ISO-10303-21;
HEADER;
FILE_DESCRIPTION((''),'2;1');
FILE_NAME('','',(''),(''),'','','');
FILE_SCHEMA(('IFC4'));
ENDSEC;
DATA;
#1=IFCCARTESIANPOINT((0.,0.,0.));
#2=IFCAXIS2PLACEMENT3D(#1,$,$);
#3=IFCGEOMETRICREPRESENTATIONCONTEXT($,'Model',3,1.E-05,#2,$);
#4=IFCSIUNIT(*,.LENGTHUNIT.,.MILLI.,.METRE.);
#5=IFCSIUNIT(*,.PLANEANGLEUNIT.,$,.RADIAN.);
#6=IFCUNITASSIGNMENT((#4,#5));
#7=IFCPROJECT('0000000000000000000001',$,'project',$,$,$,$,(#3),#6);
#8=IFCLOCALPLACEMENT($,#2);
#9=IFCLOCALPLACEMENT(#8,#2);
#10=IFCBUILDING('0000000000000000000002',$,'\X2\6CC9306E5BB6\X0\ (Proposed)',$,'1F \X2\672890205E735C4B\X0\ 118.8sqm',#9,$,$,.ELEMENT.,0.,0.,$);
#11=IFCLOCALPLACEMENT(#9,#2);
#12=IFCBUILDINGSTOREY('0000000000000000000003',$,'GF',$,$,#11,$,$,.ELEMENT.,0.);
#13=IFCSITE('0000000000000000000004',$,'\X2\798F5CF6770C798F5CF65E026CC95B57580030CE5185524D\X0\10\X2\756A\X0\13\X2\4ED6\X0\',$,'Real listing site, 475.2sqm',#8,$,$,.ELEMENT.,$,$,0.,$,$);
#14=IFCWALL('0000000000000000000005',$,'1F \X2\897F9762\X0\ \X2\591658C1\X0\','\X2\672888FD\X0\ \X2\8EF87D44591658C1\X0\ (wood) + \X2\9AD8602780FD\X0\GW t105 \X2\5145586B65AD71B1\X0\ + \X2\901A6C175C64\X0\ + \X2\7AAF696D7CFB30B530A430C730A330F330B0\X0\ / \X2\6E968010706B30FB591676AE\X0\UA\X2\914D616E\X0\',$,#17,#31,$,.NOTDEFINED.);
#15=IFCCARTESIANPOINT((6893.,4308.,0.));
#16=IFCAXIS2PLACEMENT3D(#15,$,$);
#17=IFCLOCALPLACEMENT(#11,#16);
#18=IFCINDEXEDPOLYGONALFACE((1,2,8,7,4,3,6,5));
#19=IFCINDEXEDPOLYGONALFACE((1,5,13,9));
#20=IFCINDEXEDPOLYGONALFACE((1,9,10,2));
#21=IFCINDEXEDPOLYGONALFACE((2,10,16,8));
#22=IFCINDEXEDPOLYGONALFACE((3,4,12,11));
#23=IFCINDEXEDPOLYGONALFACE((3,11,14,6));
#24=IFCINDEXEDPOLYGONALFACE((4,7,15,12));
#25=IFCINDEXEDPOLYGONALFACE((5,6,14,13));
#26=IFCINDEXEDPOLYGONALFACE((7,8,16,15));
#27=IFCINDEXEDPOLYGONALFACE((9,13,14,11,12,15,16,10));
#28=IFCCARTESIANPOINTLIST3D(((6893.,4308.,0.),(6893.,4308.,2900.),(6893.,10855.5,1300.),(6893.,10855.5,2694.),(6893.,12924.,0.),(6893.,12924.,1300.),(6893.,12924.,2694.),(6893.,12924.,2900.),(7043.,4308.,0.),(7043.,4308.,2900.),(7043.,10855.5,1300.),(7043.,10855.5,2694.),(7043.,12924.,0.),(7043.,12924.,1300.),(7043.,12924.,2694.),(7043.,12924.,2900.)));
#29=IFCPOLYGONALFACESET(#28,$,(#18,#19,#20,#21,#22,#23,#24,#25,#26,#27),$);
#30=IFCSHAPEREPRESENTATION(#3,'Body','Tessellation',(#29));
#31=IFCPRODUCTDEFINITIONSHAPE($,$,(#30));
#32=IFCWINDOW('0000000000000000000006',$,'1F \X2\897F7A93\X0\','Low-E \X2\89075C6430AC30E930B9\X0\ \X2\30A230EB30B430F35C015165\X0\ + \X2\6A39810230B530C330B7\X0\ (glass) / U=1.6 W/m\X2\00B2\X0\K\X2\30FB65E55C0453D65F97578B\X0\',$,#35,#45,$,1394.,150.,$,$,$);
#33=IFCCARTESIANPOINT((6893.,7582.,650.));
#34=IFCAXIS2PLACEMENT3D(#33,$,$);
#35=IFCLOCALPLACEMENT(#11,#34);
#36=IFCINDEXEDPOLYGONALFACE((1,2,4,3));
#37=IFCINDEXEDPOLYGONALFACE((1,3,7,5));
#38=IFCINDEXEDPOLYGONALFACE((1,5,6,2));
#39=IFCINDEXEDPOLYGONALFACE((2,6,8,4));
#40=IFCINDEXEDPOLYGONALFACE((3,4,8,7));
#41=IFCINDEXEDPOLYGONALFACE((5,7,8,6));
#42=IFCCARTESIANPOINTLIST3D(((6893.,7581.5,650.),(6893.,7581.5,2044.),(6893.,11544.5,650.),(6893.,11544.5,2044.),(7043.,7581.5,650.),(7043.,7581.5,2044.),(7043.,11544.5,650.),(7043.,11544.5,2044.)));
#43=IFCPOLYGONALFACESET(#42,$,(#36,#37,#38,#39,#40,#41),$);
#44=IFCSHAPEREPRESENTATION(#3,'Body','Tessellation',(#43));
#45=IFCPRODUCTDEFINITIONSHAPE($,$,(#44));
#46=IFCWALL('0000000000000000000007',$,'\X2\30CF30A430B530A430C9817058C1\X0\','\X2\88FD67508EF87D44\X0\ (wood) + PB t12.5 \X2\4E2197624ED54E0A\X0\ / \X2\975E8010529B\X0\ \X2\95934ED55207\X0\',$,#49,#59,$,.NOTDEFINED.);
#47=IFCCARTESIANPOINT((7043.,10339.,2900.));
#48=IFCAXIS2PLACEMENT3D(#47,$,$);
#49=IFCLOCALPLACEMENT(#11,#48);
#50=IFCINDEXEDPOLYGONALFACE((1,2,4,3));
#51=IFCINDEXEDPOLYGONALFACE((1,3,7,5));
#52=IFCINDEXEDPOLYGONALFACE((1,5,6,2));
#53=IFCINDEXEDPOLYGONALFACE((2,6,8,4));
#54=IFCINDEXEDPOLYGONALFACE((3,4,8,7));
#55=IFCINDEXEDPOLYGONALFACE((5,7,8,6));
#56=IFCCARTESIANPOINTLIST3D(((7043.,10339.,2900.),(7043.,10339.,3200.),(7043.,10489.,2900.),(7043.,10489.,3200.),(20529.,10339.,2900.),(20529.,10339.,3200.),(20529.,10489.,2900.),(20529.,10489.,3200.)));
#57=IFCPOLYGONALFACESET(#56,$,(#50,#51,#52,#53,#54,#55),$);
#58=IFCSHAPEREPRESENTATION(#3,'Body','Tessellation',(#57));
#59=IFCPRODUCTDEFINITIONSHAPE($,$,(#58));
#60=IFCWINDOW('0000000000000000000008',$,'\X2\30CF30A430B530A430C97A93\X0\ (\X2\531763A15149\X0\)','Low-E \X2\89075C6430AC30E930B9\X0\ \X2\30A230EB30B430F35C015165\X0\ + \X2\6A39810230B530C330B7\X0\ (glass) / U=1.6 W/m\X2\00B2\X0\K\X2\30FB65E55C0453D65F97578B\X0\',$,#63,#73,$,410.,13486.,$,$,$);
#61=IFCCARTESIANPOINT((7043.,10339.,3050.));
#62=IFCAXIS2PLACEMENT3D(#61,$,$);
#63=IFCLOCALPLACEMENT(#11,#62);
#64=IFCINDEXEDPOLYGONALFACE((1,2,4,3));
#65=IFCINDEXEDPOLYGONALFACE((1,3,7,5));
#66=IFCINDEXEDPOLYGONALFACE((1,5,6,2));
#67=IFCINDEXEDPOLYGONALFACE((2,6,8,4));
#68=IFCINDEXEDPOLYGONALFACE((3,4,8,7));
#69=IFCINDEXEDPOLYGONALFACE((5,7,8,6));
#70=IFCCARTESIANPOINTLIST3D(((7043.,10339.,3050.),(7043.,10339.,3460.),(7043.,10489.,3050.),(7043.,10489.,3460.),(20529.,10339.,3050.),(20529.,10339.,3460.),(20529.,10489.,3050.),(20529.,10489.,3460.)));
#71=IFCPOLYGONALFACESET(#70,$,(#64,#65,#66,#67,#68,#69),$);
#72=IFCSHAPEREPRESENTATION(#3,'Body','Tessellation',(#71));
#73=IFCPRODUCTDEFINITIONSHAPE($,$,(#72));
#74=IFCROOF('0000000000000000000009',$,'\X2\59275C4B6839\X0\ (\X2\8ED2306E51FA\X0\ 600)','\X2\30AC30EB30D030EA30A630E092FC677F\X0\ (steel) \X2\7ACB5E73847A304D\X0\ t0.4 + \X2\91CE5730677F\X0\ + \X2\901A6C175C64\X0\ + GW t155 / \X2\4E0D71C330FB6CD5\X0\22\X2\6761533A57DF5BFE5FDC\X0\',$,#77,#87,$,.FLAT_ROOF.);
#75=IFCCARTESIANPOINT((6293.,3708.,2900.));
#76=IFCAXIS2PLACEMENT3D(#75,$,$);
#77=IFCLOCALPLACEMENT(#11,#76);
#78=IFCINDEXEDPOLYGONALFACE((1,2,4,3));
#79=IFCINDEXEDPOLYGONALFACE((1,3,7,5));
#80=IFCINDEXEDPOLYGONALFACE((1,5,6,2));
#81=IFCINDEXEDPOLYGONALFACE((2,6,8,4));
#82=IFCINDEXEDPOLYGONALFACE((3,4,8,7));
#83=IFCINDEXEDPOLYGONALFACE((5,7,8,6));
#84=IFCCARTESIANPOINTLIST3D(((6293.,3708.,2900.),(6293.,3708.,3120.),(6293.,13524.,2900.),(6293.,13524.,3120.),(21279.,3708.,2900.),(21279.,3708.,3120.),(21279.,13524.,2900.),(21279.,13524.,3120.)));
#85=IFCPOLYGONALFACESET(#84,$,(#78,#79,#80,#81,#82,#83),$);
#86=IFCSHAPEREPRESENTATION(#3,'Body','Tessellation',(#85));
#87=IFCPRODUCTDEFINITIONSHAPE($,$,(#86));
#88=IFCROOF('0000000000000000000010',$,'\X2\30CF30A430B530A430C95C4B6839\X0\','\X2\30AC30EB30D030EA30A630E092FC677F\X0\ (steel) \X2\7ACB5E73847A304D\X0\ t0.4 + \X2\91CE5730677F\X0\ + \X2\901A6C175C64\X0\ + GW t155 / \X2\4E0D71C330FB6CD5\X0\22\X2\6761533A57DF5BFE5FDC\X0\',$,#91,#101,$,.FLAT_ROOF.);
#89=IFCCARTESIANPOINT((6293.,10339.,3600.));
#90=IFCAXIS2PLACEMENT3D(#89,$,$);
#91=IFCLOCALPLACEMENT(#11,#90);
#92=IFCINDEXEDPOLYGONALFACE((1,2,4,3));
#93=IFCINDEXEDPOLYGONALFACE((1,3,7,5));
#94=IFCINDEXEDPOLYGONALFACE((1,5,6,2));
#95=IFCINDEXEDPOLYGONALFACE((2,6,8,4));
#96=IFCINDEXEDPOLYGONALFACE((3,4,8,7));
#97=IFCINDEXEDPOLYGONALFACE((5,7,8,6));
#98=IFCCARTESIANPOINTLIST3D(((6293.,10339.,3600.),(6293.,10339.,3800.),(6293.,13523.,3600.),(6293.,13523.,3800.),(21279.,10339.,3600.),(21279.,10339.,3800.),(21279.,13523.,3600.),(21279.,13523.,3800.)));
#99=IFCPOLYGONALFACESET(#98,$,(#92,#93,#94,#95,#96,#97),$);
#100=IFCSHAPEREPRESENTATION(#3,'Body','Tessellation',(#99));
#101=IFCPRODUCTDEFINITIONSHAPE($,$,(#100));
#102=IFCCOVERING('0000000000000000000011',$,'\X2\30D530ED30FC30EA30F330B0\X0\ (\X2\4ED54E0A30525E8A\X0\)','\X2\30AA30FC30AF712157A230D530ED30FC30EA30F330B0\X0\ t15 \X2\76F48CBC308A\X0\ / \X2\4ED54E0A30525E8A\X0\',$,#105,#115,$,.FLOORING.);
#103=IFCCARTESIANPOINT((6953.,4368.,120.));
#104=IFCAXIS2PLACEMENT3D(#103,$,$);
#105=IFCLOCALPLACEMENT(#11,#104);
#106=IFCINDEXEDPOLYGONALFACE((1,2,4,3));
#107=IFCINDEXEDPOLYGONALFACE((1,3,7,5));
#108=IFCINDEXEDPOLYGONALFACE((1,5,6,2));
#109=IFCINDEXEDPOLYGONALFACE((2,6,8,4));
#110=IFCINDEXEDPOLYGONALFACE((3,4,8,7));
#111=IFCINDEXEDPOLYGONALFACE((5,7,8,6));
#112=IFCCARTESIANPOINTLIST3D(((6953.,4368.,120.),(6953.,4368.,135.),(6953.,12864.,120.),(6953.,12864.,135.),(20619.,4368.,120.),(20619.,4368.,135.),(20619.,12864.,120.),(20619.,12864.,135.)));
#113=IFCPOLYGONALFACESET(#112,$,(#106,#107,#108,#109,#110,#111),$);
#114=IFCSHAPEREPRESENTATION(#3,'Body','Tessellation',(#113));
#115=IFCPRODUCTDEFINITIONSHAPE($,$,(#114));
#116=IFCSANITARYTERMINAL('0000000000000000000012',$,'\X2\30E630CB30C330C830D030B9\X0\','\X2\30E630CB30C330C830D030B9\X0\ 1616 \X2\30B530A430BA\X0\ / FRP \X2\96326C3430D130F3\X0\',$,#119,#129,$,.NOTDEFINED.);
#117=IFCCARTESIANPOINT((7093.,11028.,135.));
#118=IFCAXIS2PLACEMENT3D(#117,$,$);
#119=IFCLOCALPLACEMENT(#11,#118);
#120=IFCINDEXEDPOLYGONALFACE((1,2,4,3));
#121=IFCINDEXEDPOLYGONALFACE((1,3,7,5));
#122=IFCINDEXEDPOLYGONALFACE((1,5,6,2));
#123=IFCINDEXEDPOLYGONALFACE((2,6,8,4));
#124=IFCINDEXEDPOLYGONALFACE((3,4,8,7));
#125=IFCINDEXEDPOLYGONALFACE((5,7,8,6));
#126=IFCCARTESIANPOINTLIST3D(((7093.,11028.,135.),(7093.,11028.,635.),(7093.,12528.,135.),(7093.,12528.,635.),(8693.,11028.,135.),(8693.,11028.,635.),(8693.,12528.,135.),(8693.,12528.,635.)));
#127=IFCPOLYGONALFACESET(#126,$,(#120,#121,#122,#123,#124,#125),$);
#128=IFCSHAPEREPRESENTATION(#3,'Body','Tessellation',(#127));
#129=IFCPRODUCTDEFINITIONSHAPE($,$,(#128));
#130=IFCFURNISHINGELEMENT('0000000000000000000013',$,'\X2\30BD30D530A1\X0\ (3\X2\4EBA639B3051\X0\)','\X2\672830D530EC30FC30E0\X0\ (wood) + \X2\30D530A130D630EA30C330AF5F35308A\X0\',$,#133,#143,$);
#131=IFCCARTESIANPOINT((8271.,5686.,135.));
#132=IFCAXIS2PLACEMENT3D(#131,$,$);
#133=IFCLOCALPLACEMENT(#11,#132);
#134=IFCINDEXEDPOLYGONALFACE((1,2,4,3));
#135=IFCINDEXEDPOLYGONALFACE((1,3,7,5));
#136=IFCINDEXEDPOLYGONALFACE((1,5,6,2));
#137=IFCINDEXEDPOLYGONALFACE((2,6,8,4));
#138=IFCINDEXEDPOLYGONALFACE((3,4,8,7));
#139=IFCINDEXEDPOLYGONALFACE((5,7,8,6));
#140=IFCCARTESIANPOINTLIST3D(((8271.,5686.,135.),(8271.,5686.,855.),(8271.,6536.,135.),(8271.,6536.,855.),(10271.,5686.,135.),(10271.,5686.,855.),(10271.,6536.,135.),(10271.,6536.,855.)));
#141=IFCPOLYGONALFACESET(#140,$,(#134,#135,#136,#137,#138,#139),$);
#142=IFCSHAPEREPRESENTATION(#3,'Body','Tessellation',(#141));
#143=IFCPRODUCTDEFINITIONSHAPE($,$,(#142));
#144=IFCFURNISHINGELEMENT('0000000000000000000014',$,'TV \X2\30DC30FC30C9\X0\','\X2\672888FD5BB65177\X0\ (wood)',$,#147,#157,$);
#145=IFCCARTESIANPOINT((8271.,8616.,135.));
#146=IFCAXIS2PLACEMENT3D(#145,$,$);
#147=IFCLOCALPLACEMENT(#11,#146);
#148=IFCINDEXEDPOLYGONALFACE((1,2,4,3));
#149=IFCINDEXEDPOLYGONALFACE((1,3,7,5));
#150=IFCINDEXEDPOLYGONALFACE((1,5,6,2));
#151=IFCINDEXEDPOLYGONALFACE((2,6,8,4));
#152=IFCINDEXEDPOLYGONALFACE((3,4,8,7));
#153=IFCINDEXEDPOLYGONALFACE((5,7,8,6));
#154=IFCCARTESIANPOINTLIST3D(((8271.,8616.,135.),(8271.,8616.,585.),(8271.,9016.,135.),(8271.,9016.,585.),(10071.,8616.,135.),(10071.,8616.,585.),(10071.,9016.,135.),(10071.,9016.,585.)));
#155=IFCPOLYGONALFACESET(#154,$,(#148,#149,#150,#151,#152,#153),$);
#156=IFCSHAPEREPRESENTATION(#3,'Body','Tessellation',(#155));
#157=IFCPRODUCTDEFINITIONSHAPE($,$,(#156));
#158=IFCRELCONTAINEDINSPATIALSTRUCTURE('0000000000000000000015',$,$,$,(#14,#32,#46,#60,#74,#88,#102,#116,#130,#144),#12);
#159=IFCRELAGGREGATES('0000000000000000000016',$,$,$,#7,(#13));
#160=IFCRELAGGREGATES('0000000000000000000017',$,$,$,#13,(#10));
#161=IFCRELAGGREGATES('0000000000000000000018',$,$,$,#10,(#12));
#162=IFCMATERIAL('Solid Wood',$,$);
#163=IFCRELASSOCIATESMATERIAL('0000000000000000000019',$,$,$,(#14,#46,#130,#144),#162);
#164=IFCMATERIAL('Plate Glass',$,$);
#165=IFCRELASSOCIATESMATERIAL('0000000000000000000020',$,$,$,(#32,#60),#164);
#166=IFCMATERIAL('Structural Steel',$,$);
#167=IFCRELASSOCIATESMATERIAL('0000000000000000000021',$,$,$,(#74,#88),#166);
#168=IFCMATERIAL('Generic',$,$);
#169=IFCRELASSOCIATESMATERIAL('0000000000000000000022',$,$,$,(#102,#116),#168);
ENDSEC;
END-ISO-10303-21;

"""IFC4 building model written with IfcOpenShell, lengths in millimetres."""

from ifc_helpers import new_model, si_unit, frame, frame_2d, origin, place, context, project, spatial, rectangle, extrude, material, element, fill, save


model = new_model("IFC4")

# Units and contexts
model_context = context("Model", 3, precision=1e-05, world=origin())
ifc_project = project(units=[si_unit("LENGTHUNIT", "METRE", prefix="MILLI"), si_unit("PLANEANGLEUNIT", "RADIAN")], contexts=[model_context])

# Site, building, storey
site_placement = place(None, origin())
site = spatial("IfcSite", under=ifc_project, at=site_placement, Name="福島県福島市泉字堀ノ内前10番13他", ObjectType="Real listing site, 475.2sqm", CompositionType="ELEMENT", RefElevation=0.0)
building_placement = place(site_placement, origin())
building = spatial("IfcBuilding", under=site, at=building_placement, Name="泉の家 (Proposed)", ObjectType="1F 木造平屋 118.8sqm", CompositionType="ELEMENT", ElevationOfRefHeight=0.0, ElevationOfTerrain=0.0)
storey_placement = place(building_placement, origin())
storey = spatial("IfcBuildingStorey", under=building, at=storey_placement, Name="GF", CompositionType="ELEMENT", Elevation=0.0)

# Shared definitions
ifc_material_1 = material(Name="Solid Wood")

# Shared definitions
ifc_material_2 = material(Name="Plate Glass")

# Wall, opening, window
wall_1_placement = place(storey_placement, frame((6893.0, 4308.0, 0.0)))
wall_1 = element("IfcWall", 1, at=wall_1_placement, inside=storey, material=ifc_material_1, Name="1F 西面 外壁", Description="木製 軸組外壁 (wood) + 高性能GW t105 充填断熱 + 通気層 + 窯業系サイディング / 準耐火・外皮UA配慮", PredefinedType="NOTDEFINED", context=model_context, shape_type="SweptSolid", body=[
    extrude(rectangle(XDim=150.0, YDim=8616.0, at=frame_2d((75.0, 4308.0))), frame((6893.0, 4308.0, 0.0)), (0.0, 0.0, 1.0), 2900.0),
])
opening_1_placement = place(storey_placement, frame((6893.0, 7582.0, 650.0)))
opening_1 = element("IfcOpeningElement", 2, at=opening_1_placement, cuts=wall_1, PredefinedType="NOTDEFINED", context=model_context, shape_type="SweptSolid", body=[
    extrude(rectangle(XDim=150.0, YDim=3963.0, at=frame_2d((75.0, 1981.0))), frame((6893.0, 7582.0, 650.0)), (0.0, 0.0, 1.0), 1394.0),
])
window_1_placement = place(storey_placement, frame((6893.0, 7582.0, 650.0)))
window_1 = element("IfcWindow", 3, at=window_1_placement, inside=storey, material=ifc_material_2, Name="1F 西窓", Description="Low-E 複層ガラス アルゴン封入 + 樹脂サッシ (glass) / U=1.6 W/m²K・日射取得型", OverallHeight=1394.0, OverallWidth=150.0, context=model_context, shape_type="SweptSolid", body=[
    extrude(rectangle(XDim=150.0, YDim=3963.0, at=frame_2d((75.0, 1981.0))), frame((6893.0, 7582.0, 650.0)), (0.0, 0.0, 1.0), 1394.0),
])
fill(opening_1, window_1)

# Wall, opening, window
wall_2_placement = place(storey_placement, frame((7043.0, 10339.0, 2900.0)))
wall_2 = element("IfcWall", 4, at=wall_2_placement, inside=storey, material=ifc_material_1, Name="ハイサイド腰壁", Description="製材軸組 (wood) + PB t12.5 両面仕上 / 非耐力 間仕切", PredefinedType="NOTDEFINED", context=model_context, shape_type="SweptSolid", body=[
    extrude(rectangle(XDim=13486.0, YDim=150.0, at=frame_2d((6743.0, 75.0))), frame((7043.0, 10339.0, 2900.0)), (0.0, 0.0, 1.0), 700.0),
])
opening_2_placement = place(storey_placement, frame((7043.0, 10339.0, 3050.0)))
opening_2 = element("IfcOpeningElement", 5, at=opening_2_placement, cuts=wall_2, PredefinedType="NOTDEFINED", context=model_context, shape_type="SweptSolid", body=[
    extrude(rectangle(XDim=13486.0, YDim=150.0, at=frame_2d((6743.0, 75.0))), frame((7043.0, 10339.0, 3050.0)), (0.0, 0.0, 1.0), 410.0),
])
window_2_placement = place(storey_placement, frame((7043.0, 10339.0, 3050.0)))
window_2 = element("IfcWindow", 6, at=window_2_placement, inside=storey, material=ifc_material_2, Name="ハイサイド窓 (北採光)", Description="Low-E 複層ガラス アルゴン封入 + 樹脂サッシ (glass) / U=1.6 W/m²K・日射取得型", OverallHeight=410.0, OverallWidth=13486.0, context=model_context, shape_type="SweptSolid", body=[
    extrude(rectangle(XDim=13486.0, YDim=150.0, at=frame_2d((6743.0, 75.0))), frame((7043.0, 10339.0, 3050.0)), (0.0, 0.0, 1.0), 410.0),
])
fill(opening_2, window_2)

# Roofs
ifc_material_3 = material(Name="Structural Steel")
roof_1_placement = place(storey_placement, frame((6293.0, 3708.0, 2900.0)))
element("IfcRoof", 7, at=roof_1_placement, inside=storey, material=ifc_material_3, Name="大屋根 (軒の出 600)", Description="ガルバリウム鋼板 (steel) 立平葺き t0.4 + 野地板 + 通気層 + GW t155 / 不燃・法22条区域対応", PredefinedType="FLAT_ROOF", context=model_context, shape_type="SweptSolid", body=[
    extrude(rectangle(XDim=14986.0, YDim=9816.0, at=frame_2d((7493.0, 4908.0))), frame((6293.0, 3708.0, 2900.0)), (0.0, 0.0, 1.0), 220.0),
])
roof_2_placement = place(storey_placement, frame((6293.0, 10339.0, 3600.0)))
element("IfcRoof", 8, at=roof_2_placement, inside=storey, material=ifc_material_3, Name="ハイサイド屋根", Description="ガルバリウム鋼板 (steel) 立平葺き t0.4 + 野地板 + 通気層 + GW t155 / 不燃・法22条区域対応", PredefinedType="FLAT_ROOF", context=model_context, shape_type="SweptSolid", body=[
    extrude(rectangle(XDim=14986.0, YDim=3184.0, at=frame_2d((7493.0, 1592.0))), frame((6293.0, 10339.0, 3600.0)), (0.0, 0.0, 1.0), 200.0),
])

# Covering
ifc_material_4 = material(Name="Generic")
covering_placement = place(storey_placement, frame((6953.0, 4368.0, 120.0)))
element("IfcCovering", 9, at=covering_placement, inside=storey, material=ifc_material_4, Name="フローリング (仕上げ床)", Description="オーク無垢フローリング t15 直貼り / 仕上げ床", PredefinedType="FLOORING", context=model_context, shape_type="SweptSolid", body=[
    extrude(rectangle(XDim=13666.0, YDim=8496.0, at=frame_2d((6833.0, 4248.0))), frame((6953.0, 4368.0, 120.0)), (0.0, 0.0, 1.0), 15.0),
])

# Sanitary terminal
sanitary_terminal_placement = place(storey_placement, frame((7093.0, 11028.0, 135.0)))
element("IfcSanitaryTerminal", 10, at=sanitary_terminal_placement, inside=storey, material=ifc_material_4, Name="ユニットバス", Description="ユニットバス 1616 サイズ / FRP 防水パン", PredefinedType="NOTDEFINED", context=model_context, shape_type="SweptSolid", body=[
    extrude(rectangle(XDim=1600.0, YDim=1500.0, at=frame_2d((800.0, 750.0))), frame((7093.0, 11028.0, 135.0)), (0.0, 0.0, 1.0), 500.0),
])

# Furnishing elements
furnishing_1_placement = place(storey_placement, frame((8271.0, 5686.0, 135.0)))
element("IfcFurnishingElement", 11, at=furnishing_1_placement, inside=storey, material=ifc_material_1, Name="ソファ (3人掛け)", Description="木フレーム (wood) + ファブリック張り", context=model_context, shape_type="SweptSolid", body=[
    extrude(rectangle(XDim=2000.0, YDim=850.0, at=frame_2d((1000.0, 425.0))), frame((8271.0, 5686.0, 135.0)), (0.0, 0.0, 1.0), 720.0),
])
furnishing_2_placement = place(storey_placement, frame((8271.0, 8616.0, 135.0)))
element("IfcFurnishingElement", 12, at=furnishing_2_placement, inside=storey, material=ifc_material_1, Name="TV ボード", Description="木製家具 (wood)", context=model_context, shape_type="SweptSolid", body=[
    extrude(rectangle(XDim=1800.0, YDim=400.0, at=frame_2d((900.0, 200.0))), frame((8271.0, 8616.0, 135.0)), (0.0, 0.0, 1.0), 450.0),
])

save(model, "model.ifc")
